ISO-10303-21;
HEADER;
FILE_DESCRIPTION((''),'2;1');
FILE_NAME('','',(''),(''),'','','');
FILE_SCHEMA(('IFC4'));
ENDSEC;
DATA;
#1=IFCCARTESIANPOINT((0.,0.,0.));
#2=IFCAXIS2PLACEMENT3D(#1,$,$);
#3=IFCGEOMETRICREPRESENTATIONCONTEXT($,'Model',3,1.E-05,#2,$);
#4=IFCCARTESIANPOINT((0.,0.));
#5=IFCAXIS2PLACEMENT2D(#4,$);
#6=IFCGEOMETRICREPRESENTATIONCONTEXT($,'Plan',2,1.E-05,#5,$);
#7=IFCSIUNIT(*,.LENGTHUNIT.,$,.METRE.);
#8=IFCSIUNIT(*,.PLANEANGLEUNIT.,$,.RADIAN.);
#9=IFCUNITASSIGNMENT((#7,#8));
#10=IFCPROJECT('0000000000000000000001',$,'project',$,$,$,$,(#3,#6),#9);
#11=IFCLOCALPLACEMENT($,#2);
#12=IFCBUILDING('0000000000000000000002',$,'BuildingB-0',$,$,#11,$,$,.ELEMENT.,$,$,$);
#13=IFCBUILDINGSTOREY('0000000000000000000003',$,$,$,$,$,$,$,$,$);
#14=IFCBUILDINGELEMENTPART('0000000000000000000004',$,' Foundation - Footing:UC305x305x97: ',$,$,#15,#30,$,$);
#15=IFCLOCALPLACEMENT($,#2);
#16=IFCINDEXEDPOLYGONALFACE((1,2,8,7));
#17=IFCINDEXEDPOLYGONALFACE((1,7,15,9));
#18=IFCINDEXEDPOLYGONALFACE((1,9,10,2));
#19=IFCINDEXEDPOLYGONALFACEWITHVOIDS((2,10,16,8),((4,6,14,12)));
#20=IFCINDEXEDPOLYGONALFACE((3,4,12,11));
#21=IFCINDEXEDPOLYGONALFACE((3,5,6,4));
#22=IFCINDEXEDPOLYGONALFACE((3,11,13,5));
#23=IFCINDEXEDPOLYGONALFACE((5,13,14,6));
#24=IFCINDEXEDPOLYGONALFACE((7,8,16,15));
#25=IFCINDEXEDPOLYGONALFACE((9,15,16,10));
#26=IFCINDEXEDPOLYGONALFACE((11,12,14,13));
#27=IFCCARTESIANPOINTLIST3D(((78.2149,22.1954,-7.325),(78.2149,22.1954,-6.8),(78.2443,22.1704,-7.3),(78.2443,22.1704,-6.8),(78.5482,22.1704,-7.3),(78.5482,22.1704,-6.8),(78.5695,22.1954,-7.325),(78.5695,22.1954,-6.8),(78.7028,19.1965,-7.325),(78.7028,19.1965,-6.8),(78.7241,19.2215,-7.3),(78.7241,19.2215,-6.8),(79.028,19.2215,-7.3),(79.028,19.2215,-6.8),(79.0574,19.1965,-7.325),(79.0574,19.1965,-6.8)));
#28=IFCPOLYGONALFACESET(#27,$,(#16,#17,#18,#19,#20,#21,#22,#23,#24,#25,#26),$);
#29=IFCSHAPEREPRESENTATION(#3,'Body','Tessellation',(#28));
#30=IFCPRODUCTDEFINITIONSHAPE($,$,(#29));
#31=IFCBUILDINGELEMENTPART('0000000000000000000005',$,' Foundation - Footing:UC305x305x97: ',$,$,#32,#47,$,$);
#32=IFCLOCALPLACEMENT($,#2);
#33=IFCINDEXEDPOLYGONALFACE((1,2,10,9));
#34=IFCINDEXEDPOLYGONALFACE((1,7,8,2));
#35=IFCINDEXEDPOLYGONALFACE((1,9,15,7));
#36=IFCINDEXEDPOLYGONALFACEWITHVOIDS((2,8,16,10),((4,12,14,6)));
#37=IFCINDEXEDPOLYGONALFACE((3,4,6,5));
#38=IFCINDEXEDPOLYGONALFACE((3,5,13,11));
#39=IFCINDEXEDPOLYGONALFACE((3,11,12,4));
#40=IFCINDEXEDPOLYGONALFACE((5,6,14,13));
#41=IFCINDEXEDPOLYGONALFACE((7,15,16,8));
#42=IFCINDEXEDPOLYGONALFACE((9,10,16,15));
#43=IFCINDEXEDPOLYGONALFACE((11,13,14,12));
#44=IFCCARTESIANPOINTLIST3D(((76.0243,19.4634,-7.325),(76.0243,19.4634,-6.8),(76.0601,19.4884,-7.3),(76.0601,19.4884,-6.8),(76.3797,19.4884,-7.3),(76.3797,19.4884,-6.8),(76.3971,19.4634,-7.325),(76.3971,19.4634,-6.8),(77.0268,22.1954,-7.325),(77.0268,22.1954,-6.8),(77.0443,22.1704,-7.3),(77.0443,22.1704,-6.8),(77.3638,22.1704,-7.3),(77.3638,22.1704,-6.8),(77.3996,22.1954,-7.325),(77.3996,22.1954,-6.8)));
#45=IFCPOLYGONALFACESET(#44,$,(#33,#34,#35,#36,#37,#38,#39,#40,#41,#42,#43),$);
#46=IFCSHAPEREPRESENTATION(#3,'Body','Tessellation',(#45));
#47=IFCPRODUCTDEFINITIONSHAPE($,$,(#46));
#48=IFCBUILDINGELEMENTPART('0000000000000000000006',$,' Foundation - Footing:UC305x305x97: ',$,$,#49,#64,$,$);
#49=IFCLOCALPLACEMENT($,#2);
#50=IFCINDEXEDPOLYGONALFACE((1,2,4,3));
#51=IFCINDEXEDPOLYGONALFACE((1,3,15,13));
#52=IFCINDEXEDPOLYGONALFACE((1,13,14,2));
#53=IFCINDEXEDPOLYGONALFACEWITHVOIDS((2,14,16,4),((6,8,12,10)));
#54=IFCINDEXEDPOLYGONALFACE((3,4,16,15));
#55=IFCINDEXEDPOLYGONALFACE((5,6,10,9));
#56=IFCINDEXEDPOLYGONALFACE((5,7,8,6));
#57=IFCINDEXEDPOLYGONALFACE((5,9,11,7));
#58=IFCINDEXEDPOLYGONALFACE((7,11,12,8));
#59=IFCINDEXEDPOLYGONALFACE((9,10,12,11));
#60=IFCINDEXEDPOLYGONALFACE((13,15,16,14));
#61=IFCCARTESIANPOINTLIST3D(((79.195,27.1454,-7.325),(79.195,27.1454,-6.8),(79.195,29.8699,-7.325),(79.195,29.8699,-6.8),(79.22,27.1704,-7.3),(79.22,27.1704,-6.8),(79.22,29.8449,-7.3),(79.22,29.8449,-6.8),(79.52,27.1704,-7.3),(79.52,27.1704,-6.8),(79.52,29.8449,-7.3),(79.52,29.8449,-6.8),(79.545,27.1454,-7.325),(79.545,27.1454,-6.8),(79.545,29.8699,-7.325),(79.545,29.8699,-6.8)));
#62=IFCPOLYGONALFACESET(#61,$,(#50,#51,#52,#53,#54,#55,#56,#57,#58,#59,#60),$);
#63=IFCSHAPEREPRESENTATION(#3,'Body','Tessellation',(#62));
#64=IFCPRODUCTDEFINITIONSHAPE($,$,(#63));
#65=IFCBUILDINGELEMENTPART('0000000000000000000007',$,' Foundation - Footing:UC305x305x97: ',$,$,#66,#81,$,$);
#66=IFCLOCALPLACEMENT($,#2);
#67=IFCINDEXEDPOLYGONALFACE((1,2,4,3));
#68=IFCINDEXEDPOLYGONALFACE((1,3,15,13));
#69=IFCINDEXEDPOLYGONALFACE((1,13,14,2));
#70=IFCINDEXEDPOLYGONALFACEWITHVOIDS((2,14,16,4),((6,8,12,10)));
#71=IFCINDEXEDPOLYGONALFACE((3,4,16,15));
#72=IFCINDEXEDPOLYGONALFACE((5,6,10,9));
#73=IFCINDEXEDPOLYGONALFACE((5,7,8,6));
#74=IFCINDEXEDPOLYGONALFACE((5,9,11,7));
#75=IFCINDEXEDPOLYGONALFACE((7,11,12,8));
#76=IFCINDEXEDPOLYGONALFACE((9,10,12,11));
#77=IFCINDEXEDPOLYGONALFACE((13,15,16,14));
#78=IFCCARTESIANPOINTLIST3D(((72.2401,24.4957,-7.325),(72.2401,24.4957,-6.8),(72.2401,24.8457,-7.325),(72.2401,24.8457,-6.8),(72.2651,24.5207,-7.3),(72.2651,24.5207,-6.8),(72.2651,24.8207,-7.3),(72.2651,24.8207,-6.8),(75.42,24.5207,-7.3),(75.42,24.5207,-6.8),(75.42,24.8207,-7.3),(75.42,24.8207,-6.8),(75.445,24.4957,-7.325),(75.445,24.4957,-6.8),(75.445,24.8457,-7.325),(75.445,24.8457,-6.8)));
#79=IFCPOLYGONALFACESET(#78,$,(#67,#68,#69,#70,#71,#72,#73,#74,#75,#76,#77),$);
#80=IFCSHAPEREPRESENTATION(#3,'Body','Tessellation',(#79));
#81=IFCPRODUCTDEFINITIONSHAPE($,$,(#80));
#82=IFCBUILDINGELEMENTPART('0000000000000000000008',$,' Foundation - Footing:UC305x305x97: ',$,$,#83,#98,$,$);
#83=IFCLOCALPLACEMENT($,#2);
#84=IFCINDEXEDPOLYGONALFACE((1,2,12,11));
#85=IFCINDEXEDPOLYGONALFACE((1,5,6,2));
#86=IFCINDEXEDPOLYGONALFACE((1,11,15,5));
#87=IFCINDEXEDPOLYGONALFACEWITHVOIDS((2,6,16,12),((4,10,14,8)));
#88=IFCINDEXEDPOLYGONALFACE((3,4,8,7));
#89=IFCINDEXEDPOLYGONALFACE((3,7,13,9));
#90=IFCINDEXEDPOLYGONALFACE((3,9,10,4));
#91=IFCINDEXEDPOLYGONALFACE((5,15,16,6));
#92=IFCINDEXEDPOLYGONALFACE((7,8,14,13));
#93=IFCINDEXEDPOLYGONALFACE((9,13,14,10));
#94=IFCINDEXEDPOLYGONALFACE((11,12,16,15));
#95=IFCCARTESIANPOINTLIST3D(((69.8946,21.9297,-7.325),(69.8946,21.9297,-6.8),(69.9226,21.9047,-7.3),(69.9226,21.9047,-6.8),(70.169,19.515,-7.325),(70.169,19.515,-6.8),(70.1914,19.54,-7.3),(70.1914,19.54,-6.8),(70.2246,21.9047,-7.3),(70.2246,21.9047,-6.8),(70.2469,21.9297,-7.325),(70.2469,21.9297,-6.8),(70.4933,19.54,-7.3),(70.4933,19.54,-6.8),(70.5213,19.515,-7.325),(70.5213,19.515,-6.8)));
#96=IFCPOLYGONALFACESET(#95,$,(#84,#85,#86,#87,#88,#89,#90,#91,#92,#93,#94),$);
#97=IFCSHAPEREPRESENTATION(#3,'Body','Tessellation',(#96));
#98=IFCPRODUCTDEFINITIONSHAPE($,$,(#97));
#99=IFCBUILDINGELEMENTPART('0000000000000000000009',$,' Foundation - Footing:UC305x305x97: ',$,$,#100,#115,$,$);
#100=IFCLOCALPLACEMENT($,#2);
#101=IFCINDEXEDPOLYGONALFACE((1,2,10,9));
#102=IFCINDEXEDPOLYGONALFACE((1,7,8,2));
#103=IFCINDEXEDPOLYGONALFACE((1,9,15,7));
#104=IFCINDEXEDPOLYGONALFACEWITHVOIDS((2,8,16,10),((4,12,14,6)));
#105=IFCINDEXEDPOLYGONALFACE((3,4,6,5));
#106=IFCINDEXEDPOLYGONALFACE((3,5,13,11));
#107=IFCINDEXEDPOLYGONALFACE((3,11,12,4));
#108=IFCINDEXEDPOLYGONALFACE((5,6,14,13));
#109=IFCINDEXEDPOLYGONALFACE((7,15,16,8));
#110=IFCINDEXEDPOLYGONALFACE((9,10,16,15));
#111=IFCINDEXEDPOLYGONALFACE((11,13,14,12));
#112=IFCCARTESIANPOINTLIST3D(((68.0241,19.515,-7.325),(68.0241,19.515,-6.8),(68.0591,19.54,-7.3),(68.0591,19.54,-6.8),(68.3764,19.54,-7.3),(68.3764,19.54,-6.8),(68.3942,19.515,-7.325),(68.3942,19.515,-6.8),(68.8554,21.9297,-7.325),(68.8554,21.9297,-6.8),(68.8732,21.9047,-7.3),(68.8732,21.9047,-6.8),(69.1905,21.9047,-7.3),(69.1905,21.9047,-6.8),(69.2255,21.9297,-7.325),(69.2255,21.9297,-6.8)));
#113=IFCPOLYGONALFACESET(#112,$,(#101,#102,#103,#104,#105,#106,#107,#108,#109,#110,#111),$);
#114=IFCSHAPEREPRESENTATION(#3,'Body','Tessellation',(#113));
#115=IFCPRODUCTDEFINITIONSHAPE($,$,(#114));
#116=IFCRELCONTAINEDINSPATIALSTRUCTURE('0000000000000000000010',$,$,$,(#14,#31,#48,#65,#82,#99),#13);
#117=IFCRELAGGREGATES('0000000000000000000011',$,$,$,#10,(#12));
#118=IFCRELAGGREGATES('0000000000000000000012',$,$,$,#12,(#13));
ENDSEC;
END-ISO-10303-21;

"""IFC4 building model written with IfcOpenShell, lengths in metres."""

from ifc_helpers import new_model, si_unit, origin, origin_2d, place, context, project, spatial, polyline, outline, extrude, element, save


model = new_model("IFC4")

# Units and contexts
model_context = context("Model", 3, precision=1e-05, world=origin())
plan_context = context("Plan", 2, precision=1e-05, world=origin_2d())
ifc_project = project(units=[si_unit("LENGTHUNIT", "METRE"), si_unit("PLANEANGLEUNIT", "RADIAN")], contexts=[model_context, plan_context])

# Building, storey
building_placement = place(None, origin())
building = spatial("IfcBuilding", under=ifc_project, at=building_placement, Name="BuildingB-0", CompositionType="ELEMENT")
storey = spatial("IfcBuildingStorey", under=building)

# Building element parts, openings
building_element_part_1 = element("IfcBuildingElementPart", 1, inside=storey, Name=" Foundation - Footing:UC305x305x97: ", context=model_context, shape_type="SweptSolid", body=[
    extrude(outline(polyline([(79.0574, 19.1965, -7.325), (78.7028, 19.1965, -7.325), (78.2149, 22.1954, -7.325), (78.5695, 22.1954, -7.325), (79.0574, 19.1965, -7.325)])), None, (0.0, 0.0, 1.0), 0.525),
])
element("IfcOpeningElement", 2, inside=storey, cuts=building_element_part_1, context=model_context, shape_type="SweptSolid", body=[
    extrude(outline(polyline([(79.028, 19.2215, -7.3), (78.7241, 19.2215, -7.3), (78.2443, 22.1704, -7.3), (78.5482, 22.1704, -7.3), (79.028, 19.2215, -7.3)])), None, (0.0, 0.0, 1.0), 0.5),
])
building_element_part_2 = element("IfcBuildingElementPart", 3, inside=storey, Name=" Foundation - Footing:UC305x305x97: ", context=model_context, shape_type="SweptSolid", body=[
    extrude(outline(polyline([(76.3971, 19.4634, -7.325), (76.0243, 19.4634, -7.325), (77.0268, 22.1954, -7.325), (77.3996, 22.1954, -7.325), (76.3971, 19.4634, -7.325)])), None, (0.0, 0.0, 1.0), 0.525),
])
element("IfcOpeningElement", 4, inside=storey, cuts=building_element_part_2, context=model_context, shape_type="SweptSolid", body=[
    extrude(outline(polyline([(76.3797, 19.4884, -7.3), (76.0601, 19.4884, -7.3), (77.0443, 22.1704, -7.3), (77.3638, 22.1704, -7.3), (76.3797, 19.4884, -7.3)])), None, (0.0, 0.0, 1.0), 0.5),
])
building_element_part_3 = element("IfcBuildingElementPart", 5, inside=storey, Name=" Foundation - Footing:UC305x305x97: ", context=model_context, shape_type="SweptSolid", body=[
    extrude(outline(polyline([(79.545, 27.1454, -7.325), (79.195, 27.1454, -7.325), (79.195, 29.8699, -7.325), (79.545, 29.8699, -7.325), (79.545, 27.1454, -7.325)])), None, (0.0, 0.0, 1.0), 0.525),
])
element("IfcOpeningElement", 6, inside=storey, cuts=building_element_part_3, context=model_context, shape_type="SweptSolid", body=[
    extrude(outline(polyline([(79.52, 27.1704, -7.3), (79.22, 27.1704, -7.3), (79.22, 29.8449, -7.3), (79.52, 29.8449, -7.3), (79.52, 27.1704, -7.3)])), None, (0.0, 0.0, 1.0), 0.5),
])
building_element_part_4 = element("IfcBuildingElementPart", 7, inside=storey, Name=" Foundation - Footing:UC305x305x97: ", context=model_context, shape_type="SweptSolid", body=[
    extrude(outline(polyline([(75.445, 24.4957, -7.325), (75.445, 24.8457, -7.325), (72.2401, 24.8457, -7.325), (72.2401, 24.4957, -7.325), (75.445, 24.4957, -7.325)])), None, (0.0, 0.0, 1.0), 0.525),
])
element("IfcOpeningElement", 8, inside=storey, cuts=building_element_part_4, context=model_context, shape_type="SweptSolid", body=[
    extrude(outline(polyline([(75.42, 24.5207, -7.3), (75.42, 24.8207, -7.3), (72.2651, 24.8207, -7.3), (72.2651, 24.5207, -7.3), (75.42, 24.5207, -7.3)])), None, (0.0, 0.0, 1.0), 0.5),
])
building_element_part_5 = element("IfcBuildingElementPart", 9, inside=storey, Name=" Foundation - Footing:UC305x305x97: ", context=model_context, shape_type="SweptSolid", body=[
    extrude(outline(polyline([(70.5213, 19.515, -7.325), (70.169, 19.515, -7.325), (69.8946, 21.9297, -7.325), (70.2469, 21.9297, -7.325), (70.5213, 19.515, -7.325)])), None, (0.0, 0.0, 1.0), 0.525),
])
element("IfcOpeningElement", 10, inside=storey, cuts=building_element_part_5, context=model_context, shape_type="SweptSolid", body=[
    extrude(outline(polyline([(70.4933, 19.54, -7.3), (70.1914, 19.54, -7.3), (69.9226, 21.9047, -7.3), (70.2246, 21.9047, -7.3), (70.4933, 19.54, -7.3)])), None, (0.0, 0.0, 1.0), 0.5),
])
building_element_part_6 = element("IfcBuildingElementPart", 11, inside=storey, Name=" Foundation - Footing:UC305x305x97: ", context=model_context, shape_type="SweptSolid", body=[
    extrude(outline(polyline([(68.3942, 19.515, -7.325), (68.0241, 19.515, -7.325), (68.8554, 21.9297, -7.325), (69.2255, 21.9297, -7.325), (68.3942, 19.515, -7.325)])), None, (0.0, 0.0, 1.0), 0.525),
])
element("IfcOpeningElement", 12, inside=storey, cuts=building_element_part_6, context=model_context, shape_type="SweptSolid", body=[
    extrude(outline(polyline([(68.3764, 19.54, -7.3), (68.0591, 19.54, -7.3), (68.8732, 21.9047, -7.3), (69.1905, 21.9047, -7.3), (68.3764, 19.54, -7.3)])), None, (0.0, 0.0, 1.0), 0.5),
])

save(model, "model.ifc")
